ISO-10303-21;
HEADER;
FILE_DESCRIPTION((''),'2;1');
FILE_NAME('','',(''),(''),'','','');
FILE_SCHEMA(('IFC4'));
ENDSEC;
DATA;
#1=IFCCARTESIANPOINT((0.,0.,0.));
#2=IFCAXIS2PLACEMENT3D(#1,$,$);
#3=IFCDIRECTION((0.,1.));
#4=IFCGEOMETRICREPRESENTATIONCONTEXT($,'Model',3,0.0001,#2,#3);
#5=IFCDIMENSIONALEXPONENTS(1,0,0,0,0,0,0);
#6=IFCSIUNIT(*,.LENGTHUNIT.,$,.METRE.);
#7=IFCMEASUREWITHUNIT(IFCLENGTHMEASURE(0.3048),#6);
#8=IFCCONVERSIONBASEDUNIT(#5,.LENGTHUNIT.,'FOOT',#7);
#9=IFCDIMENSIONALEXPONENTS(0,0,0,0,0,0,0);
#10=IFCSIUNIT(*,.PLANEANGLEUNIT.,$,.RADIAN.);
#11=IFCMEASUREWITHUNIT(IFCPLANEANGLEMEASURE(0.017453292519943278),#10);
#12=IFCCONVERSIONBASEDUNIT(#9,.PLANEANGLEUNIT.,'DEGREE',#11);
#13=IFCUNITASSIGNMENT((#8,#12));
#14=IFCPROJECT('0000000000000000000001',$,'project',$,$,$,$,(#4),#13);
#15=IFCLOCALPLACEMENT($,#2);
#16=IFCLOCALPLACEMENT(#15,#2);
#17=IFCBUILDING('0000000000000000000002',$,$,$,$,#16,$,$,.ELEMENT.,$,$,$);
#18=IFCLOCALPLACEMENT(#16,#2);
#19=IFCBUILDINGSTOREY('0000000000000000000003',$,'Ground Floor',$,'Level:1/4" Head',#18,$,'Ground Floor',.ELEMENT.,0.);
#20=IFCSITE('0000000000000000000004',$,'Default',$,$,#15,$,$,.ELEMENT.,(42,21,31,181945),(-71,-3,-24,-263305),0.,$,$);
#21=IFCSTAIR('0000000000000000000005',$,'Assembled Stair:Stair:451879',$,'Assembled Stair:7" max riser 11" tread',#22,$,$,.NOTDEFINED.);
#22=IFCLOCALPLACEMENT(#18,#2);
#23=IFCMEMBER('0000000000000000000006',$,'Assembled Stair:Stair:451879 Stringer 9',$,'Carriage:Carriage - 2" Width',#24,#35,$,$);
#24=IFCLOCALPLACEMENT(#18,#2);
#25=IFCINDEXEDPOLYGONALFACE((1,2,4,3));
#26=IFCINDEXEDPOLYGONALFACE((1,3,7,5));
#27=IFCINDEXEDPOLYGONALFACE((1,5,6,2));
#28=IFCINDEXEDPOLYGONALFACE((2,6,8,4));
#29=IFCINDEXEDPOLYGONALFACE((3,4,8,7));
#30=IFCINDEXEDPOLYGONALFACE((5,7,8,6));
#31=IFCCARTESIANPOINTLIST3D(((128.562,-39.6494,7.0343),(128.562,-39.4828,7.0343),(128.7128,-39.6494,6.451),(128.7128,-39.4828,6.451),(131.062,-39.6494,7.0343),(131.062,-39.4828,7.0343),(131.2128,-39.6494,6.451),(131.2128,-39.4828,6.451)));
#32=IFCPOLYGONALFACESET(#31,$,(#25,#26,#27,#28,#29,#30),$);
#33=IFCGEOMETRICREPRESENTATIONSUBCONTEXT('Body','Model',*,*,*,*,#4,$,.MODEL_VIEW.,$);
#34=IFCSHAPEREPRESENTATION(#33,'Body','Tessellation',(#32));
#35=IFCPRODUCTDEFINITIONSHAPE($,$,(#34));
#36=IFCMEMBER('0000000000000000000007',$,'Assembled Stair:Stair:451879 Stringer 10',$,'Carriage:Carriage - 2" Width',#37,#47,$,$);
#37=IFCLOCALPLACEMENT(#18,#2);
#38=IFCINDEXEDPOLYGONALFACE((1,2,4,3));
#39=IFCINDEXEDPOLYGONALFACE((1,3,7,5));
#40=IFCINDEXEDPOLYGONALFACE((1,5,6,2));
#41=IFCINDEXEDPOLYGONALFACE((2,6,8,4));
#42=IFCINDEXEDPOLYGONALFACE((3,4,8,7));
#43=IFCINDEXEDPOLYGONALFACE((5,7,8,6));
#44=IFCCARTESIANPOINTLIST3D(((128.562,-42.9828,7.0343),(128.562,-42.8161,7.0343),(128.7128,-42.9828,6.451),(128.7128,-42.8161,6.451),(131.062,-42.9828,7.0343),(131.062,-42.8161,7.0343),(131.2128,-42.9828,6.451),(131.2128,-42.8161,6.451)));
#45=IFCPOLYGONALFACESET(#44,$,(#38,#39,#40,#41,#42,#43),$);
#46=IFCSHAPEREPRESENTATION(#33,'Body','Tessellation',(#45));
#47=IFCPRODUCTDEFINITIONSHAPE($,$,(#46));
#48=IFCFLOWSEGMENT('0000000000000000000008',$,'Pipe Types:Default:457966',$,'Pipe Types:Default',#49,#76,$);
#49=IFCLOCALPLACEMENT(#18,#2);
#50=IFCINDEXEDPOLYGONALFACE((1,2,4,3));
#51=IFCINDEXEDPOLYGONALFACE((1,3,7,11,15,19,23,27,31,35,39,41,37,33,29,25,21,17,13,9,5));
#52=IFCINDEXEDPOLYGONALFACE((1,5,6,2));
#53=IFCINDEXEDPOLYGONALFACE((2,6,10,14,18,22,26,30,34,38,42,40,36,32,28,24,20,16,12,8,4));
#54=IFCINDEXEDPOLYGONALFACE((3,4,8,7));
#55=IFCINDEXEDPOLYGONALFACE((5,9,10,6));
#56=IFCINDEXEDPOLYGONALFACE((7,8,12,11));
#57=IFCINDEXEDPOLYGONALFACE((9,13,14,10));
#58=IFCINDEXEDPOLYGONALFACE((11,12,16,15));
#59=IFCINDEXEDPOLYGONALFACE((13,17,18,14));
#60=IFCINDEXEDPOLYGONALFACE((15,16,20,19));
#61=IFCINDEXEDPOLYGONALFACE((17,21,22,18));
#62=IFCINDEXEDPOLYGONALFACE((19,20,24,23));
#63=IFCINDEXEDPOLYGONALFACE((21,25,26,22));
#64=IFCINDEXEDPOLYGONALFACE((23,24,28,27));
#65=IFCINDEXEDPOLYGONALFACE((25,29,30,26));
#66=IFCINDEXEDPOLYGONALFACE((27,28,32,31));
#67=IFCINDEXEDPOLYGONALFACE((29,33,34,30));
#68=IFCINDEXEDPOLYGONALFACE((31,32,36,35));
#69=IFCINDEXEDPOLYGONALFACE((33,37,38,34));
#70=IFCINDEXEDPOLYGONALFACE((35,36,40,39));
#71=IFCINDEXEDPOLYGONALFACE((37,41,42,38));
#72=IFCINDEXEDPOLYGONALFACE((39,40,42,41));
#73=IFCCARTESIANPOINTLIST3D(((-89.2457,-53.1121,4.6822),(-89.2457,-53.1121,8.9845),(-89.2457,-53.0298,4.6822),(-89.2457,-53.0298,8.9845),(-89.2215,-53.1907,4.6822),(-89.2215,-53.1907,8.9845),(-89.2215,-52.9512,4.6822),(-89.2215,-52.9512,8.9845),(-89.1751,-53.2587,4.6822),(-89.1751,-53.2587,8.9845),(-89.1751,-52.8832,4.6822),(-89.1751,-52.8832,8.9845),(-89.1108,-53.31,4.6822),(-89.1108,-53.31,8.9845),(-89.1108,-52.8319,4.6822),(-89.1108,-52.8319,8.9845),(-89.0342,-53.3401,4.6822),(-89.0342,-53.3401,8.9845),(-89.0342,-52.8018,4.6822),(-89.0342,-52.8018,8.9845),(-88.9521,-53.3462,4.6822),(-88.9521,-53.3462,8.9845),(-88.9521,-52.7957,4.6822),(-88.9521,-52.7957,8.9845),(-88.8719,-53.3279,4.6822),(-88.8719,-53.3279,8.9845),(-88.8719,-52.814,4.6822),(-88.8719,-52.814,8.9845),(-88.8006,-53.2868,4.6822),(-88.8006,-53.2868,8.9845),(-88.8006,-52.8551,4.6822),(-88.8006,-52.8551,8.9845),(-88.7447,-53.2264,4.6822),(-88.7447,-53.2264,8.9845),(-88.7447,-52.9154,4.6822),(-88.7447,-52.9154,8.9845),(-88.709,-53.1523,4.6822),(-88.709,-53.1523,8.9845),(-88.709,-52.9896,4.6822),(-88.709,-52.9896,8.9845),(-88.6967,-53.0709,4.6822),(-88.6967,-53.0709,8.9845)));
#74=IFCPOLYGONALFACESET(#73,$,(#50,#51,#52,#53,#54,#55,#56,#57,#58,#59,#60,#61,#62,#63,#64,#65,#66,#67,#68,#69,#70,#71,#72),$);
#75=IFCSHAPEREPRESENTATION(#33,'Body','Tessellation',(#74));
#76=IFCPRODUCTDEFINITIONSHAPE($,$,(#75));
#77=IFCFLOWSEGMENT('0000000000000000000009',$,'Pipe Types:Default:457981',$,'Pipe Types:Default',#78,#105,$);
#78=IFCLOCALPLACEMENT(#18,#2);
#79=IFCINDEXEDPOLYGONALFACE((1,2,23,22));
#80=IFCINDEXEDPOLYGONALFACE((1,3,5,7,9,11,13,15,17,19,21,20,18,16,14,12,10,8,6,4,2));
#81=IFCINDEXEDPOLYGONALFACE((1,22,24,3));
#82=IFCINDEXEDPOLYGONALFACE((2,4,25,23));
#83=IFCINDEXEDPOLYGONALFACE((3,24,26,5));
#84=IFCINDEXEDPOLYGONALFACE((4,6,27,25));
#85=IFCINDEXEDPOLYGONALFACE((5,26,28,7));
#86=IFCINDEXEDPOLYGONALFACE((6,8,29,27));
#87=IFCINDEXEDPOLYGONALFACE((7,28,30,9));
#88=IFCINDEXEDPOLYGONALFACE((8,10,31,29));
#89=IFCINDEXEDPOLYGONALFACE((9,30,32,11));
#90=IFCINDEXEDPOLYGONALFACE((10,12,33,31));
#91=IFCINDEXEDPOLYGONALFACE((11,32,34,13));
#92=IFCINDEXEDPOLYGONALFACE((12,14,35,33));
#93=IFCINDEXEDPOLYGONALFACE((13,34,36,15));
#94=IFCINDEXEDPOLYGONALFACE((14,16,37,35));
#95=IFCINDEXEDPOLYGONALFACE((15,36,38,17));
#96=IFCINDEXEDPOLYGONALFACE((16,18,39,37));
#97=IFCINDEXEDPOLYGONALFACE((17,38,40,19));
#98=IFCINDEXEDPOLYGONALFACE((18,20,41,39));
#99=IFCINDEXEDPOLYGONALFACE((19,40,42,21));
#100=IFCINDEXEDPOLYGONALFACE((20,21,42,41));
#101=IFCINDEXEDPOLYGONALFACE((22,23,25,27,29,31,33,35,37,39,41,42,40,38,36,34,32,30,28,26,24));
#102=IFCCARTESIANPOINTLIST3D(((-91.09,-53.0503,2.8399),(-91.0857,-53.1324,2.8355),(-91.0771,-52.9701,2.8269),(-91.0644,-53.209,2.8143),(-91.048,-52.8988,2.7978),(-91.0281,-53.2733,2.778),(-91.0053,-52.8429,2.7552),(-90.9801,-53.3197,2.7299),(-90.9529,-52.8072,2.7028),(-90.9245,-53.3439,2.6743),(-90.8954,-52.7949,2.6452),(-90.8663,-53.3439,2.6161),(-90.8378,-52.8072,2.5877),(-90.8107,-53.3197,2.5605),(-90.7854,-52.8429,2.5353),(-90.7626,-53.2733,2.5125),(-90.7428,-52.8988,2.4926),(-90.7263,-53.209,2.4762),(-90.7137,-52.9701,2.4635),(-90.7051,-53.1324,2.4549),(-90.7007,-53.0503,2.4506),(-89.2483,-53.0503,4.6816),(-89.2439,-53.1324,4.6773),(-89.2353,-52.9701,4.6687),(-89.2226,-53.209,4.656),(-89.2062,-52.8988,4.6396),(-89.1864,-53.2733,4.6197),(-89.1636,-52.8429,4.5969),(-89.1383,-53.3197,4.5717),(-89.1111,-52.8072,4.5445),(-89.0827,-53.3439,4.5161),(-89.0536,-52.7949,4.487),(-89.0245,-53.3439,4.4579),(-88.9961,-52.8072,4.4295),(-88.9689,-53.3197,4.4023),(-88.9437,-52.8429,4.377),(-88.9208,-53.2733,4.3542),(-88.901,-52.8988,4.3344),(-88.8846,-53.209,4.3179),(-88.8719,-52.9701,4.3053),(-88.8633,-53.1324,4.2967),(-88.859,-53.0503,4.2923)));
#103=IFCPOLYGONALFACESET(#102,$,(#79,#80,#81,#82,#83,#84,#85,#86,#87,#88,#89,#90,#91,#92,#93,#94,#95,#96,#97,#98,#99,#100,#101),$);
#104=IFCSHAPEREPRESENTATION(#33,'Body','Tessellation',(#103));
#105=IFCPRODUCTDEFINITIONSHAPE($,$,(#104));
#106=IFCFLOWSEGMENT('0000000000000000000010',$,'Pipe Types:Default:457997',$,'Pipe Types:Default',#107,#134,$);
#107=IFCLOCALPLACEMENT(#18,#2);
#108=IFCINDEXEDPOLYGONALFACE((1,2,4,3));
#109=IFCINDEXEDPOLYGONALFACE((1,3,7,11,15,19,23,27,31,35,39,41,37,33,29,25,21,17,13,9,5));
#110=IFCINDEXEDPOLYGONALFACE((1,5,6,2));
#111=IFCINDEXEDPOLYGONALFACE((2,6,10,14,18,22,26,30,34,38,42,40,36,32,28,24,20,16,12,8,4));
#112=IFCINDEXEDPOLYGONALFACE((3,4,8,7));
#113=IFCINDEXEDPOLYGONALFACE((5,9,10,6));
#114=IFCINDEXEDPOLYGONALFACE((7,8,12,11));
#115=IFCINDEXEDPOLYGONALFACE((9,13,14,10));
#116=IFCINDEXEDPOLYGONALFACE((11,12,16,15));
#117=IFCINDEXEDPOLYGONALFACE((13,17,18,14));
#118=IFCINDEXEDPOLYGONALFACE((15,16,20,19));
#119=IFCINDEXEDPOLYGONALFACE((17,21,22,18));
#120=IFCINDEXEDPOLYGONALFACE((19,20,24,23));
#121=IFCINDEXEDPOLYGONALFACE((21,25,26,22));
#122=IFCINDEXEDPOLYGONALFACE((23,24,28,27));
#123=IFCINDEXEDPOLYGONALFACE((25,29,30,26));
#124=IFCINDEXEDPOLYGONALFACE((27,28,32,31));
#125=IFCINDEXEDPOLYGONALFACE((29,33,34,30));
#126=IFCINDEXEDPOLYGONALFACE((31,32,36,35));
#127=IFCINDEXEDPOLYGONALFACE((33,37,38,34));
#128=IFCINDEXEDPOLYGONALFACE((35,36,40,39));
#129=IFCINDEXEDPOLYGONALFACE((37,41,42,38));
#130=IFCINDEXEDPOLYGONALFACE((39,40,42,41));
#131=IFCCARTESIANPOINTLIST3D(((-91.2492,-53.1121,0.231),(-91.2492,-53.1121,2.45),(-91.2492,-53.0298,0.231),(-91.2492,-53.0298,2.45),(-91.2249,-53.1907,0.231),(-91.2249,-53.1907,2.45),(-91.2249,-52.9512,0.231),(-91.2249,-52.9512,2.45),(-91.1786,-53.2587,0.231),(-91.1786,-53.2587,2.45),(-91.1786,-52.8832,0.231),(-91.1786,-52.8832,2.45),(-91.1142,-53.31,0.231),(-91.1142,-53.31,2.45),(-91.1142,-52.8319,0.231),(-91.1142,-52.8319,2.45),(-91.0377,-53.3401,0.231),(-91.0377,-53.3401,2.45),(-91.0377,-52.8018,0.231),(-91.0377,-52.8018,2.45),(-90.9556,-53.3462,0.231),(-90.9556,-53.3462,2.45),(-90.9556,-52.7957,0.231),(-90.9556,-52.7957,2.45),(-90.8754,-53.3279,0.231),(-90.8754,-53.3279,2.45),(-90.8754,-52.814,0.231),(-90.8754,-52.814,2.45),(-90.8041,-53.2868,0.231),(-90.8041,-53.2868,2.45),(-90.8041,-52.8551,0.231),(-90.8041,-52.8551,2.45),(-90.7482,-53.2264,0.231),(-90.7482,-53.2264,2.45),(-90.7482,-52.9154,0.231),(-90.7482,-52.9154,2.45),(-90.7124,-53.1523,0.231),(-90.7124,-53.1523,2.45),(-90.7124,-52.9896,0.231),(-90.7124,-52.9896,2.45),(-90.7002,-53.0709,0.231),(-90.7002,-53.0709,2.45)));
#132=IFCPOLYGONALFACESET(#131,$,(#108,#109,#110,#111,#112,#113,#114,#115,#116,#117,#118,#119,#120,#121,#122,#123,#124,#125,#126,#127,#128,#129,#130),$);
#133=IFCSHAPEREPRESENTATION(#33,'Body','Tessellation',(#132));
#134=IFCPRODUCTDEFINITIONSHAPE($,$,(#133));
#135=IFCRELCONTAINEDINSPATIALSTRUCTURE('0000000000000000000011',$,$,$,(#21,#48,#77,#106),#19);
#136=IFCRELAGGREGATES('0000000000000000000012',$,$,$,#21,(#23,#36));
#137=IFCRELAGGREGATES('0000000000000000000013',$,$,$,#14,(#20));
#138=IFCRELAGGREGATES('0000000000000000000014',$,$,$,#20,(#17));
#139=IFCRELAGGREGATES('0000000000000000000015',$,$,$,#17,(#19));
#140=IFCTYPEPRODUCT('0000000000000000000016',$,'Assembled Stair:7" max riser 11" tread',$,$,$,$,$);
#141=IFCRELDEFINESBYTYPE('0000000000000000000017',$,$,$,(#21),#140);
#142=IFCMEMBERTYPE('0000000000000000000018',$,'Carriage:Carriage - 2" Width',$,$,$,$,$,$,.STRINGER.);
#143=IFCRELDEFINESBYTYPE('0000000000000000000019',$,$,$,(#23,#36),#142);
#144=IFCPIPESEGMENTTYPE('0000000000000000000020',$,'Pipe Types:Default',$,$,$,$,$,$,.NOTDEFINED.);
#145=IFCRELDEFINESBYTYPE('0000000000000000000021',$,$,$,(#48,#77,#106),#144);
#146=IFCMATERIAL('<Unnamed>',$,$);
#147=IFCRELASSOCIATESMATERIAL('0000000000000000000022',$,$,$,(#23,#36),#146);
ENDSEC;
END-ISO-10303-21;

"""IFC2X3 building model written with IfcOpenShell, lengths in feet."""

from ifc_helpers import new_model, entity, si_unit, converted_unit, direction, frame, frame_2d, origin, origin_2d_with_axis, place, context, subcontext, project, spatial, polyline, circle, outline, extrude, material, type_object, element, aggregate, save


model = new_model("IFC2X3")

# Units and contexts
model_context = context("Model", 3, precision=0.0001, world=origin(), true_north=direction((0.0, 1.0)))
body_context = subcontext(model_context, "Body", "Model", "MODEL_VIEW")
ifc_project = project(units=[converted_unit("LENGTHUNIT", "FOOT", entity("IfcLengthMeasure", 0.3048), si_unit("LENGTHUNIT", "METRE"), dimensions=[1, 0, 0, 0, 0, 0, 0]), converted_unit("PLANEANGLEUNIT", "DEGREE", entity("IfcPlaneAngleMeasure", 0.017453292519943278), si_unit("PLANEANGLEUNIT", "RADIAN"), dimensions=[0, 0, 0, 0, 0, 0, 0])], contexts=[model_context])

# Site, building, storey
site_placement = place(None, origin())
site = spatial("IfcSite", under=ifc_project, at=site_placement, Name="Default", CompositionType="ELEMENT", RefLatitude=(42, 21, 31, 181945), RefLongitude=(-71, -3, -24, -263305), RefElevation=0.0)
building_placement = place(site_placement, origin())
building = spatial("IfcBuilding", under=site, at=building_placement, CompositionType="ELEMENT")
storey_placement = place(building_placement, origin())
storey = spatial("IfcBuildingStorey", under=building, at=storey_placement, Name="Ground Floor", ObjectType="Level:1/4\" Head", LongName="Ground Floor", CompositionType="ELEMENT", Elevation=0.0)

# Stair, members
type_product_1 = type_object("IfcTypeProduct", Name="Assembled Stair:7\" max riser 11\" tread")
stair_1_placement = place(storey_placement, origin())
stair_1 = element("IfcStair", 1, at=stair_1_placement, inside=storey, type_object=type_product_1, Name="Assembled Stair:Stair:451879", ObjectType="Assembled Stair:7\" max riser 11\" tread", ShapeType="NOTDEFINED")
ifc_material_1 = material(Name="<Unnamed>")
member_type = type_object("IfcMemberType", Name="Carriage:Carriage - 2\" Width", PredefinedType="STRINGER")
member_1_placement = place(stair_1_placement, origin())
member_1 = element("IfcMember", 2, at=member_1_placement, type_object=member_type, material=ifc_material_1, Name="Assembled Stair:Stair:451879 Stringer 9", ObjectType="Carriage:Carriage - 2\" Width", context=body_context, shape_type="SweptSolid", body=[
    extrude(outline(polyline([(0.0115, -1.2102), (0.614, -1.2102), (-0.0115, 1.2102), (-0.614, 1.2102), (0.0115, -1.2102)])), frame((129.8874, -39.6494, 6.7426), z_axis=(0.0, 1.0, 0.0), x_axis=(-0.250236, 0.0, 0.968185)), (0.0, 0.0, 1.0), 0.1667),
])
member_2_placement = place(stair_1_placement, origin())
member_2 = element("IfcMember", 3, at=member_2_placement, type_object=member_type, material=ifc_material_1, Name="Assembled Stair:Stair:451879 Stringer 10", ObjectType="Carriage:Carriage - 2\" Width", context=body_context, shape_type="SweptSolid", body=[
    extrude(outline(polyline([(0.0115, -1.2102), (0.614, -1.2102), (-0.0115, 1.2102), (-0.614, 1.2102), (0.0115, -1.2102)])), frame((129.8874, -42.9828, 6.7426), z_axis=(0.0, 1.0, 0.0), x_axis=(-0.250236, 0.0, 0.968185)), (0.0, 0.0, 1.0), 0.1667),
])
aggregate(stair_1, [member_1, member_2])

# Flow segments
pipe_segment_type = type_object("IfcPipeSegmentType", Name="Pipe Types:Default", PredefinedType="NOTDEFINED")
flow_segment_1_placement = place(storey_placement, origin())
element("IfcFlowSegment", 4, at=flow_segment_1_placement, inside=storey, type_object=pipe_segment_type, Name="Pipe Types:Default:457966", ObjectType="Pipe Types:Default", context=body_context, shape_type="SweptSolid", body=[
    extrude(circle(Radius=0.276, at=origin_2d_with_axis()), frame((-88.9728, -53.0709, 4.6822)), (0.0, 0.0, 1.0), 4.3023),
])
flow_segment_2_placement = place(storey_placement, origin())
element("IfcFlowSegment", 5, at=flow_segment_2_placement, inside=storey, type_object=pipe_segment_type, Name="Pipe Types:Default:457981", ObjectType="Pipe Types:Default", context=body_context, shape_type="SweptSolid", body=[
    extrude(circle(Radius=0.276, at=frame_2d((0.0, 0.0), x_axis=(1.0, 0.0))), frame((-90.8954, -53.0709, 2.6452), z_axis=(0.707107, 0.0, 0.707107), x_axis=(0.0, 1.0, 0.0)), (0.0, 0.0, 1.0), 2.6047),
])
flow_segment_3_placement = place(storey_placement, origin())
element("IfcFlowSegment", 6, at=flow_segment_3_placement, inside=storey, type_object=pipe_segment_type, Name="Pipe Types:Default:457997", ObjectType="Pipe Types:Default", context=body_context, shape_type="SweptSolid", body=[
    extrude(circle(Radius=0.276, at=origin_2d_with_axis()), frame((-90.9762, -53.0709, 0.231)), (0.0, 0.0, 1.0), 2.219),
])

save(model, "model.ifc")
